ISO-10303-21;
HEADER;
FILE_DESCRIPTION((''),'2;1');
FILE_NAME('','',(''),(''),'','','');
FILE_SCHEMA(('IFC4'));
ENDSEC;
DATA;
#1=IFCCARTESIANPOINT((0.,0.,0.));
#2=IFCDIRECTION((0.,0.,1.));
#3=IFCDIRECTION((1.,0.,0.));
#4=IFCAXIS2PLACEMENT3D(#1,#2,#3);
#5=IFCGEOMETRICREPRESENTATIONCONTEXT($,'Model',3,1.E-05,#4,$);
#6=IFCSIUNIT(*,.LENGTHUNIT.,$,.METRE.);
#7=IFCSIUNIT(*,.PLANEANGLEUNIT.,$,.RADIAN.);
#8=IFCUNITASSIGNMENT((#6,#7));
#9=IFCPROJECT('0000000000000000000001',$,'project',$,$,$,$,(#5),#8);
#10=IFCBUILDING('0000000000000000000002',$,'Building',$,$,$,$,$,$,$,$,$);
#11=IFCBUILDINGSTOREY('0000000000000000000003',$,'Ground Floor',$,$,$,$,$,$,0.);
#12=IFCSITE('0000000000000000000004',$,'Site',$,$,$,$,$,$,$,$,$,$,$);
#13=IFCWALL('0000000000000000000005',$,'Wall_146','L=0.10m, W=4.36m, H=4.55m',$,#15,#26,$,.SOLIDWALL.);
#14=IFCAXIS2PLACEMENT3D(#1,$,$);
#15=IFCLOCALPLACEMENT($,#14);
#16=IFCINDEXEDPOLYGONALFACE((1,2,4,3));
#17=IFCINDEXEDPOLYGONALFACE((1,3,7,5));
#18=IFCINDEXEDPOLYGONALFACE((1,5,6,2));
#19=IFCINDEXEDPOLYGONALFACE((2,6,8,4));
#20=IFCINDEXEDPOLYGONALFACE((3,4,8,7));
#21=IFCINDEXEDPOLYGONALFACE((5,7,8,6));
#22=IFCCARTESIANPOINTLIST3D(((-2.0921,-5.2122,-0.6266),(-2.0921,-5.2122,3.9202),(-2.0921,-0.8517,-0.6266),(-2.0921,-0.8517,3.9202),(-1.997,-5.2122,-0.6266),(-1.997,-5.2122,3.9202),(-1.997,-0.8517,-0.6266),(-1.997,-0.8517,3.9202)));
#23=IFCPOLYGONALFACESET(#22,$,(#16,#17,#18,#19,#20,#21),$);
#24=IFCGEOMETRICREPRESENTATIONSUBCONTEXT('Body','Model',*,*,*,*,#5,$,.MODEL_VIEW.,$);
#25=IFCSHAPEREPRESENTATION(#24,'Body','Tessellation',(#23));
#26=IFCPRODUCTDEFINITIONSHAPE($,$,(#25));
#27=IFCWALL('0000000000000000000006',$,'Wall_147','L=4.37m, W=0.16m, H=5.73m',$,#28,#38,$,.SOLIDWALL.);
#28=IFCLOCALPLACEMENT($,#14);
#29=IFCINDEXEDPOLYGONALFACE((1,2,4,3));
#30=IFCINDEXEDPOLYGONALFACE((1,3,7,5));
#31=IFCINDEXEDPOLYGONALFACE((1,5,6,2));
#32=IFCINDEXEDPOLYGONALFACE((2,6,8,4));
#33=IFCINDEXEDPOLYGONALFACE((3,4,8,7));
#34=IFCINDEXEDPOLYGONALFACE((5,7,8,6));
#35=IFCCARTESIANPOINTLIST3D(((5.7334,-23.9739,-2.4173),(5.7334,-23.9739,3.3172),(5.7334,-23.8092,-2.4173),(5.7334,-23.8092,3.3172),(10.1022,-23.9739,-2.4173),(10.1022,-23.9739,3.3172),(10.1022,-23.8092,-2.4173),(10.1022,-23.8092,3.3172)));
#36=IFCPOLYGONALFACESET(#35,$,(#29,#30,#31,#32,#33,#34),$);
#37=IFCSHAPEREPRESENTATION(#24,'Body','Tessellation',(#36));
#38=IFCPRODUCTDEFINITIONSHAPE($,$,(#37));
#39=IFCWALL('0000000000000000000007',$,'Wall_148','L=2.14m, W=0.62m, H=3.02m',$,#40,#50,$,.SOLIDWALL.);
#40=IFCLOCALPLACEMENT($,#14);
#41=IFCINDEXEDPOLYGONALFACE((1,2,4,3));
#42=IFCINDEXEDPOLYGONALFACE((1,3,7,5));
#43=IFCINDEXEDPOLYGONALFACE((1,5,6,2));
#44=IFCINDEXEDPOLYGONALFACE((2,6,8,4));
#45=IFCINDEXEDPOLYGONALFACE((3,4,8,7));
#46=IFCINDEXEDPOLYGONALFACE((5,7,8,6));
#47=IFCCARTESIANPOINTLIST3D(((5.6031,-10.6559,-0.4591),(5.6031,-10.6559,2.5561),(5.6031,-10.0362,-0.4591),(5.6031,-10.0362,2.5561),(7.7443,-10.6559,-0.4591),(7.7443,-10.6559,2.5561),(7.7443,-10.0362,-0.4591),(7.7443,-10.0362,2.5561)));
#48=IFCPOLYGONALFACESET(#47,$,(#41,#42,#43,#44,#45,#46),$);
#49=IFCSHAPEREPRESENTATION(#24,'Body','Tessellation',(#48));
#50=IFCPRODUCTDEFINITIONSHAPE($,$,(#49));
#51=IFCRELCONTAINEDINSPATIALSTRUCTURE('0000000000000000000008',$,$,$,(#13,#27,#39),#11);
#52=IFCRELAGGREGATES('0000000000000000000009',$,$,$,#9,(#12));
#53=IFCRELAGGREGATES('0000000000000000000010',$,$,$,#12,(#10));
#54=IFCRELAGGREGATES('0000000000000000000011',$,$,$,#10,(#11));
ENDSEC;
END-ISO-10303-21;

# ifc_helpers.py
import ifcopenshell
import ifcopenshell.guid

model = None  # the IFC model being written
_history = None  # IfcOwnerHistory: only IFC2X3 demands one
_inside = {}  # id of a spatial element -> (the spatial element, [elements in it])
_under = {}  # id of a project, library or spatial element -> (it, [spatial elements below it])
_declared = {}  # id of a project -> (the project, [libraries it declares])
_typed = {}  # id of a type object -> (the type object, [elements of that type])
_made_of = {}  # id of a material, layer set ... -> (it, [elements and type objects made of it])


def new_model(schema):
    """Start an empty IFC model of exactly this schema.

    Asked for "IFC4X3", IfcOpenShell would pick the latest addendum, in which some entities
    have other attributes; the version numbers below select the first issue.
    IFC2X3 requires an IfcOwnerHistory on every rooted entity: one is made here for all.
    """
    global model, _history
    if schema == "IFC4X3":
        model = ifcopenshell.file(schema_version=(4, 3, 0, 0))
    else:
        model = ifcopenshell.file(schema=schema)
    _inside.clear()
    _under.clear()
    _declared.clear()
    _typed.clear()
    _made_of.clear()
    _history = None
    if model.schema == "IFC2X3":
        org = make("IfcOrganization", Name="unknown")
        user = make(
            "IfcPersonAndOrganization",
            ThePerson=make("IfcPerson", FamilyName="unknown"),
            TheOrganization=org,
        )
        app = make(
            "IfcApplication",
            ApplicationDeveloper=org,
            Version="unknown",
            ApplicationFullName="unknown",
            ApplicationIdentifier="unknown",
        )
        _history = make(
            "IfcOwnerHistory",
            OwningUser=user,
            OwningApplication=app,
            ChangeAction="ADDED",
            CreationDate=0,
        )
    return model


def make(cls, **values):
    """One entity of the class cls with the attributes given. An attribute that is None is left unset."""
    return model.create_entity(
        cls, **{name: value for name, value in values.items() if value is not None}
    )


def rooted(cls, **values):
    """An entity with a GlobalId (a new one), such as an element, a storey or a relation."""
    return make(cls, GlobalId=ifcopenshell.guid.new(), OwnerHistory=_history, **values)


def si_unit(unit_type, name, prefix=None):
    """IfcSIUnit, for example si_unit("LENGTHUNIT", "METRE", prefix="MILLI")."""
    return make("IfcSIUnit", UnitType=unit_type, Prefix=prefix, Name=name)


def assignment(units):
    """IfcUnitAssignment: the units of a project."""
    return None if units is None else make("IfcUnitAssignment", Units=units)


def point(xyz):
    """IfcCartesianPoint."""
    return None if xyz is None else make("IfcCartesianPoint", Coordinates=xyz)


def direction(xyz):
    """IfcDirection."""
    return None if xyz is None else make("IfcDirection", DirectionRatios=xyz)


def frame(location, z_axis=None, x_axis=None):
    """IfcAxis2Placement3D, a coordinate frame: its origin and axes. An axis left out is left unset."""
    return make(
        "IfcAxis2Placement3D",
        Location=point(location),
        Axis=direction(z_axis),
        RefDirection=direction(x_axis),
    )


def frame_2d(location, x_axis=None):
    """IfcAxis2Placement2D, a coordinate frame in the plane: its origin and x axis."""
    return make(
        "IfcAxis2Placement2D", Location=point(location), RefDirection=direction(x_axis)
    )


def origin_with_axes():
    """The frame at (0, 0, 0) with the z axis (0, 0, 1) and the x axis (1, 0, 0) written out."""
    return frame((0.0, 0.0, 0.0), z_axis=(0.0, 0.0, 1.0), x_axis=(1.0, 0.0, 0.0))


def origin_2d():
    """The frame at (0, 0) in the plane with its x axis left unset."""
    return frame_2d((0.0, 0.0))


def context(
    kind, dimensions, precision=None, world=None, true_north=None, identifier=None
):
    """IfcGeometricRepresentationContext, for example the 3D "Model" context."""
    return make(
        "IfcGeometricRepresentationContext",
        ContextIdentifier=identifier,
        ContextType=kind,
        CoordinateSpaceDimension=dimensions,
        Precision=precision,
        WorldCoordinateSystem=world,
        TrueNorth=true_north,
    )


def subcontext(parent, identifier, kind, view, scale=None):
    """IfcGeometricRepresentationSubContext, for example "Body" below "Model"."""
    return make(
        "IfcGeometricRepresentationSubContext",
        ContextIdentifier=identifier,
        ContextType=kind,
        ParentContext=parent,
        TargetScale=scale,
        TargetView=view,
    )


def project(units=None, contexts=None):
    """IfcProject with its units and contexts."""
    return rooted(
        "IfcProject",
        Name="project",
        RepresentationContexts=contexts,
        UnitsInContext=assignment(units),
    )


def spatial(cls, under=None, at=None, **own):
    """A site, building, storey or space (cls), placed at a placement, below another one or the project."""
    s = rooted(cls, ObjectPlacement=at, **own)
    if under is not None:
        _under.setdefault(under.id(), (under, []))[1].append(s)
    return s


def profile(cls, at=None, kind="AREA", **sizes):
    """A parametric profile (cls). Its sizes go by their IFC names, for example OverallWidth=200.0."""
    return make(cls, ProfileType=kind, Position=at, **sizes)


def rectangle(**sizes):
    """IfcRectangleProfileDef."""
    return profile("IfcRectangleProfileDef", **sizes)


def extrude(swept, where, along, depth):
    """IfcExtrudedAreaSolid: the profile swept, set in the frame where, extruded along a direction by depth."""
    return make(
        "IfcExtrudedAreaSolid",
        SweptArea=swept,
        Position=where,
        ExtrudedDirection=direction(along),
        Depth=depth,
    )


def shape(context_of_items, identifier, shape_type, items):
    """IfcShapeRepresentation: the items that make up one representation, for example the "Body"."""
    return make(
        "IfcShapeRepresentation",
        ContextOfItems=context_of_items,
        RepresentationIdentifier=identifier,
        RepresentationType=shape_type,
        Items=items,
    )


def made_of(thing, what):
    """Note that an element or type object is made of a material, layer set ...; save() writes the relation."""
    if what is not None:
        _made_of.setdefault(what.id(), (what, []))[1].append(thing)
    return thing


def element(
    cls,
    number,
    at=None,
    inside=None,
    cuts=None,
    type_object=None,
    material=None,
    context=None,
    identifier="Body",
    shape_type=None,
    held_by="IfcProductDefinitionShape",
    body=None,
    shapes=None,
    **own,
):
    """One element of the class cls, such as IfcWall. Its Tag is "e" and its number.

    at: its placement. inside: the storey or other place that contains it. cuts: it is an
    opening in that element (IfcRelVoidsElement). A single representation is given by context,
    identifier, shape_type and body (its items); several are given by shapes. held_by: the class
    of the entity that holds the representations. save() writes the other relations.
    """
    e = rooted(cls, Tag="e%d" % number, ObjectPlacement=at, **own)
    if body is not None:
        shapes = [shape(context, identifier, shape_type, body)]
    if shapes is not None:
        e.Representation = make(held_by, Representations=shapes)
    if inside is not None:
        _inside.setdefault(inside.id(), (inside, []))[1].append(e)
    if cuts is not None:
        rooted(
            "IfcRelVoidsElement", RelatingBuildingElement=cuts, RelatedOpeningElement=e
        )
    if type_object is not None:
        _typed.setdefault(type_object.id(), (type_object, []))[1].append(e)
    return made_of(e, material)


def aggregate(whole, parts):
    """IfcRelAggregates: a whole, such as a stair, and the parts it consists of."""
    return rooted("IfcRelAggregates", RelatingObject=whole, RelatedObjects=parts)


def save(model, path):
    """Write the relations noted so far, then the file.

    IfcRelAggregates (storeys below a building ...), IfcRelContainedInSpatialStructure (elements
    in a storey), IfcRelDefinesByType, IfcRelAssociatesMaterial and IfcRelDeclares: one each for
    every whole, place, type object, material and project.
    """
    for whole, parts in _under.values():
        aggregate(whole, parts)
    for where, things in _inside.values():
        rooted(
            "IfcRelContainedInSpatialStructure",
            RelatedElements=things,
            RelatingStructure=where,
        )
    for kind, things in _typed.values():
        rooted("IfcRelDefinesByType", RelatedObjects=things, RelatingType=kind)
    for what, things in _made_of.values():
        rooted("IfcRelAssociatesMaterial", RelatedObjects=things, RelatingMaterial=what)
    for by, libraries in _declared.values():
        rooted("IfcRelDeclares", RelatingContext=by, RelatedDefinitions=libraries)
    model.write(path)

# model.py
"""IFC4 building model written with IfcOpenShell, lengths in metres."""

from ifc_helpers import new_model, si_unit, frame, origin_with_axes, origin_2d, context, subcontext, project, spatial, rectangle, extrude, element, save


model = new_model("IFC4")

# Units and contexts
model_context = context("Model", 3, precision=1e-05, world=origin_with_axes())
body_context = subcontext(model_context, "Body", "Model", "MODEL_VIEW")
ifc_project = project(units=[si_unit("LENGTHUNIT", "METRE"), si_unit("PLANEANGLEUNIT", "RADIAN")], contexts=[model_context])

# Site, building, storey
site = spatial("IfcSite", under=ifc_project, Name="Site")
building = spatial("IfcBuilding", under=site, Name="Building")
storey = spatial("IfcBuildingStorey", under=building, Name="Ground Floor", Elevation=0.0)

# Walls
element("IfcWall", 1, inside=storey, Name="Wall_146", Description="L=0.10m, W=4.36m, H=4.55m", PredefinedType="SOLIDWALL", context=body_context, shape_type="SweptSolid", body=[
    extrude(rectangle(XDim=0.0952, YDim=4.3605, at=origin_2d()), frame((-2.0445, -3.0319, -0.6266), z_axis=(0.0, 0.0, 1.0), x_axis=(1.0, 0.0, 0.0)), (0.0, 0.0, 1.0), 4.5468),
])
element("IfcWall", 2, inside=storey, Name="Wall_147", Description="L=4.37m, W=0.16m, H=5.73m", PredefinedType="SOLIDWALL", context=body_context, shape_type="SweptSolid", body=[
    extrude(rectangle(XDim=4.3689, YDim=0.1647, at=origin_2d()), frame((7.9178, -23.8915, -2.4173), z_axis=(0.0, 0.0, 1.0), x_axis=(1.0, 0.0, 0.0)), (0.0, 0.0, 1.0), 5.7345),
])
element("IfcWall", 3, inside=storey, Name="Wall_148", Description="L=2.14m, W=0.62m, H=3.02m", PredefinedType="SOLIDWALL", context=body_context, shape_type="SweptSolid", body=[
    extrude(rectangle(XDim=2.1412, YDim=0.6196, at=origin_2d()), frame((6.6737, -10.3461, -0.4591), z_axis=(0.0, 0.0, 1.0), x_axis=(1.0, 0.0, 0.0)), (0.0, 0.0, 1.0), 3.0152),
])

save(model, "model.ifc")
